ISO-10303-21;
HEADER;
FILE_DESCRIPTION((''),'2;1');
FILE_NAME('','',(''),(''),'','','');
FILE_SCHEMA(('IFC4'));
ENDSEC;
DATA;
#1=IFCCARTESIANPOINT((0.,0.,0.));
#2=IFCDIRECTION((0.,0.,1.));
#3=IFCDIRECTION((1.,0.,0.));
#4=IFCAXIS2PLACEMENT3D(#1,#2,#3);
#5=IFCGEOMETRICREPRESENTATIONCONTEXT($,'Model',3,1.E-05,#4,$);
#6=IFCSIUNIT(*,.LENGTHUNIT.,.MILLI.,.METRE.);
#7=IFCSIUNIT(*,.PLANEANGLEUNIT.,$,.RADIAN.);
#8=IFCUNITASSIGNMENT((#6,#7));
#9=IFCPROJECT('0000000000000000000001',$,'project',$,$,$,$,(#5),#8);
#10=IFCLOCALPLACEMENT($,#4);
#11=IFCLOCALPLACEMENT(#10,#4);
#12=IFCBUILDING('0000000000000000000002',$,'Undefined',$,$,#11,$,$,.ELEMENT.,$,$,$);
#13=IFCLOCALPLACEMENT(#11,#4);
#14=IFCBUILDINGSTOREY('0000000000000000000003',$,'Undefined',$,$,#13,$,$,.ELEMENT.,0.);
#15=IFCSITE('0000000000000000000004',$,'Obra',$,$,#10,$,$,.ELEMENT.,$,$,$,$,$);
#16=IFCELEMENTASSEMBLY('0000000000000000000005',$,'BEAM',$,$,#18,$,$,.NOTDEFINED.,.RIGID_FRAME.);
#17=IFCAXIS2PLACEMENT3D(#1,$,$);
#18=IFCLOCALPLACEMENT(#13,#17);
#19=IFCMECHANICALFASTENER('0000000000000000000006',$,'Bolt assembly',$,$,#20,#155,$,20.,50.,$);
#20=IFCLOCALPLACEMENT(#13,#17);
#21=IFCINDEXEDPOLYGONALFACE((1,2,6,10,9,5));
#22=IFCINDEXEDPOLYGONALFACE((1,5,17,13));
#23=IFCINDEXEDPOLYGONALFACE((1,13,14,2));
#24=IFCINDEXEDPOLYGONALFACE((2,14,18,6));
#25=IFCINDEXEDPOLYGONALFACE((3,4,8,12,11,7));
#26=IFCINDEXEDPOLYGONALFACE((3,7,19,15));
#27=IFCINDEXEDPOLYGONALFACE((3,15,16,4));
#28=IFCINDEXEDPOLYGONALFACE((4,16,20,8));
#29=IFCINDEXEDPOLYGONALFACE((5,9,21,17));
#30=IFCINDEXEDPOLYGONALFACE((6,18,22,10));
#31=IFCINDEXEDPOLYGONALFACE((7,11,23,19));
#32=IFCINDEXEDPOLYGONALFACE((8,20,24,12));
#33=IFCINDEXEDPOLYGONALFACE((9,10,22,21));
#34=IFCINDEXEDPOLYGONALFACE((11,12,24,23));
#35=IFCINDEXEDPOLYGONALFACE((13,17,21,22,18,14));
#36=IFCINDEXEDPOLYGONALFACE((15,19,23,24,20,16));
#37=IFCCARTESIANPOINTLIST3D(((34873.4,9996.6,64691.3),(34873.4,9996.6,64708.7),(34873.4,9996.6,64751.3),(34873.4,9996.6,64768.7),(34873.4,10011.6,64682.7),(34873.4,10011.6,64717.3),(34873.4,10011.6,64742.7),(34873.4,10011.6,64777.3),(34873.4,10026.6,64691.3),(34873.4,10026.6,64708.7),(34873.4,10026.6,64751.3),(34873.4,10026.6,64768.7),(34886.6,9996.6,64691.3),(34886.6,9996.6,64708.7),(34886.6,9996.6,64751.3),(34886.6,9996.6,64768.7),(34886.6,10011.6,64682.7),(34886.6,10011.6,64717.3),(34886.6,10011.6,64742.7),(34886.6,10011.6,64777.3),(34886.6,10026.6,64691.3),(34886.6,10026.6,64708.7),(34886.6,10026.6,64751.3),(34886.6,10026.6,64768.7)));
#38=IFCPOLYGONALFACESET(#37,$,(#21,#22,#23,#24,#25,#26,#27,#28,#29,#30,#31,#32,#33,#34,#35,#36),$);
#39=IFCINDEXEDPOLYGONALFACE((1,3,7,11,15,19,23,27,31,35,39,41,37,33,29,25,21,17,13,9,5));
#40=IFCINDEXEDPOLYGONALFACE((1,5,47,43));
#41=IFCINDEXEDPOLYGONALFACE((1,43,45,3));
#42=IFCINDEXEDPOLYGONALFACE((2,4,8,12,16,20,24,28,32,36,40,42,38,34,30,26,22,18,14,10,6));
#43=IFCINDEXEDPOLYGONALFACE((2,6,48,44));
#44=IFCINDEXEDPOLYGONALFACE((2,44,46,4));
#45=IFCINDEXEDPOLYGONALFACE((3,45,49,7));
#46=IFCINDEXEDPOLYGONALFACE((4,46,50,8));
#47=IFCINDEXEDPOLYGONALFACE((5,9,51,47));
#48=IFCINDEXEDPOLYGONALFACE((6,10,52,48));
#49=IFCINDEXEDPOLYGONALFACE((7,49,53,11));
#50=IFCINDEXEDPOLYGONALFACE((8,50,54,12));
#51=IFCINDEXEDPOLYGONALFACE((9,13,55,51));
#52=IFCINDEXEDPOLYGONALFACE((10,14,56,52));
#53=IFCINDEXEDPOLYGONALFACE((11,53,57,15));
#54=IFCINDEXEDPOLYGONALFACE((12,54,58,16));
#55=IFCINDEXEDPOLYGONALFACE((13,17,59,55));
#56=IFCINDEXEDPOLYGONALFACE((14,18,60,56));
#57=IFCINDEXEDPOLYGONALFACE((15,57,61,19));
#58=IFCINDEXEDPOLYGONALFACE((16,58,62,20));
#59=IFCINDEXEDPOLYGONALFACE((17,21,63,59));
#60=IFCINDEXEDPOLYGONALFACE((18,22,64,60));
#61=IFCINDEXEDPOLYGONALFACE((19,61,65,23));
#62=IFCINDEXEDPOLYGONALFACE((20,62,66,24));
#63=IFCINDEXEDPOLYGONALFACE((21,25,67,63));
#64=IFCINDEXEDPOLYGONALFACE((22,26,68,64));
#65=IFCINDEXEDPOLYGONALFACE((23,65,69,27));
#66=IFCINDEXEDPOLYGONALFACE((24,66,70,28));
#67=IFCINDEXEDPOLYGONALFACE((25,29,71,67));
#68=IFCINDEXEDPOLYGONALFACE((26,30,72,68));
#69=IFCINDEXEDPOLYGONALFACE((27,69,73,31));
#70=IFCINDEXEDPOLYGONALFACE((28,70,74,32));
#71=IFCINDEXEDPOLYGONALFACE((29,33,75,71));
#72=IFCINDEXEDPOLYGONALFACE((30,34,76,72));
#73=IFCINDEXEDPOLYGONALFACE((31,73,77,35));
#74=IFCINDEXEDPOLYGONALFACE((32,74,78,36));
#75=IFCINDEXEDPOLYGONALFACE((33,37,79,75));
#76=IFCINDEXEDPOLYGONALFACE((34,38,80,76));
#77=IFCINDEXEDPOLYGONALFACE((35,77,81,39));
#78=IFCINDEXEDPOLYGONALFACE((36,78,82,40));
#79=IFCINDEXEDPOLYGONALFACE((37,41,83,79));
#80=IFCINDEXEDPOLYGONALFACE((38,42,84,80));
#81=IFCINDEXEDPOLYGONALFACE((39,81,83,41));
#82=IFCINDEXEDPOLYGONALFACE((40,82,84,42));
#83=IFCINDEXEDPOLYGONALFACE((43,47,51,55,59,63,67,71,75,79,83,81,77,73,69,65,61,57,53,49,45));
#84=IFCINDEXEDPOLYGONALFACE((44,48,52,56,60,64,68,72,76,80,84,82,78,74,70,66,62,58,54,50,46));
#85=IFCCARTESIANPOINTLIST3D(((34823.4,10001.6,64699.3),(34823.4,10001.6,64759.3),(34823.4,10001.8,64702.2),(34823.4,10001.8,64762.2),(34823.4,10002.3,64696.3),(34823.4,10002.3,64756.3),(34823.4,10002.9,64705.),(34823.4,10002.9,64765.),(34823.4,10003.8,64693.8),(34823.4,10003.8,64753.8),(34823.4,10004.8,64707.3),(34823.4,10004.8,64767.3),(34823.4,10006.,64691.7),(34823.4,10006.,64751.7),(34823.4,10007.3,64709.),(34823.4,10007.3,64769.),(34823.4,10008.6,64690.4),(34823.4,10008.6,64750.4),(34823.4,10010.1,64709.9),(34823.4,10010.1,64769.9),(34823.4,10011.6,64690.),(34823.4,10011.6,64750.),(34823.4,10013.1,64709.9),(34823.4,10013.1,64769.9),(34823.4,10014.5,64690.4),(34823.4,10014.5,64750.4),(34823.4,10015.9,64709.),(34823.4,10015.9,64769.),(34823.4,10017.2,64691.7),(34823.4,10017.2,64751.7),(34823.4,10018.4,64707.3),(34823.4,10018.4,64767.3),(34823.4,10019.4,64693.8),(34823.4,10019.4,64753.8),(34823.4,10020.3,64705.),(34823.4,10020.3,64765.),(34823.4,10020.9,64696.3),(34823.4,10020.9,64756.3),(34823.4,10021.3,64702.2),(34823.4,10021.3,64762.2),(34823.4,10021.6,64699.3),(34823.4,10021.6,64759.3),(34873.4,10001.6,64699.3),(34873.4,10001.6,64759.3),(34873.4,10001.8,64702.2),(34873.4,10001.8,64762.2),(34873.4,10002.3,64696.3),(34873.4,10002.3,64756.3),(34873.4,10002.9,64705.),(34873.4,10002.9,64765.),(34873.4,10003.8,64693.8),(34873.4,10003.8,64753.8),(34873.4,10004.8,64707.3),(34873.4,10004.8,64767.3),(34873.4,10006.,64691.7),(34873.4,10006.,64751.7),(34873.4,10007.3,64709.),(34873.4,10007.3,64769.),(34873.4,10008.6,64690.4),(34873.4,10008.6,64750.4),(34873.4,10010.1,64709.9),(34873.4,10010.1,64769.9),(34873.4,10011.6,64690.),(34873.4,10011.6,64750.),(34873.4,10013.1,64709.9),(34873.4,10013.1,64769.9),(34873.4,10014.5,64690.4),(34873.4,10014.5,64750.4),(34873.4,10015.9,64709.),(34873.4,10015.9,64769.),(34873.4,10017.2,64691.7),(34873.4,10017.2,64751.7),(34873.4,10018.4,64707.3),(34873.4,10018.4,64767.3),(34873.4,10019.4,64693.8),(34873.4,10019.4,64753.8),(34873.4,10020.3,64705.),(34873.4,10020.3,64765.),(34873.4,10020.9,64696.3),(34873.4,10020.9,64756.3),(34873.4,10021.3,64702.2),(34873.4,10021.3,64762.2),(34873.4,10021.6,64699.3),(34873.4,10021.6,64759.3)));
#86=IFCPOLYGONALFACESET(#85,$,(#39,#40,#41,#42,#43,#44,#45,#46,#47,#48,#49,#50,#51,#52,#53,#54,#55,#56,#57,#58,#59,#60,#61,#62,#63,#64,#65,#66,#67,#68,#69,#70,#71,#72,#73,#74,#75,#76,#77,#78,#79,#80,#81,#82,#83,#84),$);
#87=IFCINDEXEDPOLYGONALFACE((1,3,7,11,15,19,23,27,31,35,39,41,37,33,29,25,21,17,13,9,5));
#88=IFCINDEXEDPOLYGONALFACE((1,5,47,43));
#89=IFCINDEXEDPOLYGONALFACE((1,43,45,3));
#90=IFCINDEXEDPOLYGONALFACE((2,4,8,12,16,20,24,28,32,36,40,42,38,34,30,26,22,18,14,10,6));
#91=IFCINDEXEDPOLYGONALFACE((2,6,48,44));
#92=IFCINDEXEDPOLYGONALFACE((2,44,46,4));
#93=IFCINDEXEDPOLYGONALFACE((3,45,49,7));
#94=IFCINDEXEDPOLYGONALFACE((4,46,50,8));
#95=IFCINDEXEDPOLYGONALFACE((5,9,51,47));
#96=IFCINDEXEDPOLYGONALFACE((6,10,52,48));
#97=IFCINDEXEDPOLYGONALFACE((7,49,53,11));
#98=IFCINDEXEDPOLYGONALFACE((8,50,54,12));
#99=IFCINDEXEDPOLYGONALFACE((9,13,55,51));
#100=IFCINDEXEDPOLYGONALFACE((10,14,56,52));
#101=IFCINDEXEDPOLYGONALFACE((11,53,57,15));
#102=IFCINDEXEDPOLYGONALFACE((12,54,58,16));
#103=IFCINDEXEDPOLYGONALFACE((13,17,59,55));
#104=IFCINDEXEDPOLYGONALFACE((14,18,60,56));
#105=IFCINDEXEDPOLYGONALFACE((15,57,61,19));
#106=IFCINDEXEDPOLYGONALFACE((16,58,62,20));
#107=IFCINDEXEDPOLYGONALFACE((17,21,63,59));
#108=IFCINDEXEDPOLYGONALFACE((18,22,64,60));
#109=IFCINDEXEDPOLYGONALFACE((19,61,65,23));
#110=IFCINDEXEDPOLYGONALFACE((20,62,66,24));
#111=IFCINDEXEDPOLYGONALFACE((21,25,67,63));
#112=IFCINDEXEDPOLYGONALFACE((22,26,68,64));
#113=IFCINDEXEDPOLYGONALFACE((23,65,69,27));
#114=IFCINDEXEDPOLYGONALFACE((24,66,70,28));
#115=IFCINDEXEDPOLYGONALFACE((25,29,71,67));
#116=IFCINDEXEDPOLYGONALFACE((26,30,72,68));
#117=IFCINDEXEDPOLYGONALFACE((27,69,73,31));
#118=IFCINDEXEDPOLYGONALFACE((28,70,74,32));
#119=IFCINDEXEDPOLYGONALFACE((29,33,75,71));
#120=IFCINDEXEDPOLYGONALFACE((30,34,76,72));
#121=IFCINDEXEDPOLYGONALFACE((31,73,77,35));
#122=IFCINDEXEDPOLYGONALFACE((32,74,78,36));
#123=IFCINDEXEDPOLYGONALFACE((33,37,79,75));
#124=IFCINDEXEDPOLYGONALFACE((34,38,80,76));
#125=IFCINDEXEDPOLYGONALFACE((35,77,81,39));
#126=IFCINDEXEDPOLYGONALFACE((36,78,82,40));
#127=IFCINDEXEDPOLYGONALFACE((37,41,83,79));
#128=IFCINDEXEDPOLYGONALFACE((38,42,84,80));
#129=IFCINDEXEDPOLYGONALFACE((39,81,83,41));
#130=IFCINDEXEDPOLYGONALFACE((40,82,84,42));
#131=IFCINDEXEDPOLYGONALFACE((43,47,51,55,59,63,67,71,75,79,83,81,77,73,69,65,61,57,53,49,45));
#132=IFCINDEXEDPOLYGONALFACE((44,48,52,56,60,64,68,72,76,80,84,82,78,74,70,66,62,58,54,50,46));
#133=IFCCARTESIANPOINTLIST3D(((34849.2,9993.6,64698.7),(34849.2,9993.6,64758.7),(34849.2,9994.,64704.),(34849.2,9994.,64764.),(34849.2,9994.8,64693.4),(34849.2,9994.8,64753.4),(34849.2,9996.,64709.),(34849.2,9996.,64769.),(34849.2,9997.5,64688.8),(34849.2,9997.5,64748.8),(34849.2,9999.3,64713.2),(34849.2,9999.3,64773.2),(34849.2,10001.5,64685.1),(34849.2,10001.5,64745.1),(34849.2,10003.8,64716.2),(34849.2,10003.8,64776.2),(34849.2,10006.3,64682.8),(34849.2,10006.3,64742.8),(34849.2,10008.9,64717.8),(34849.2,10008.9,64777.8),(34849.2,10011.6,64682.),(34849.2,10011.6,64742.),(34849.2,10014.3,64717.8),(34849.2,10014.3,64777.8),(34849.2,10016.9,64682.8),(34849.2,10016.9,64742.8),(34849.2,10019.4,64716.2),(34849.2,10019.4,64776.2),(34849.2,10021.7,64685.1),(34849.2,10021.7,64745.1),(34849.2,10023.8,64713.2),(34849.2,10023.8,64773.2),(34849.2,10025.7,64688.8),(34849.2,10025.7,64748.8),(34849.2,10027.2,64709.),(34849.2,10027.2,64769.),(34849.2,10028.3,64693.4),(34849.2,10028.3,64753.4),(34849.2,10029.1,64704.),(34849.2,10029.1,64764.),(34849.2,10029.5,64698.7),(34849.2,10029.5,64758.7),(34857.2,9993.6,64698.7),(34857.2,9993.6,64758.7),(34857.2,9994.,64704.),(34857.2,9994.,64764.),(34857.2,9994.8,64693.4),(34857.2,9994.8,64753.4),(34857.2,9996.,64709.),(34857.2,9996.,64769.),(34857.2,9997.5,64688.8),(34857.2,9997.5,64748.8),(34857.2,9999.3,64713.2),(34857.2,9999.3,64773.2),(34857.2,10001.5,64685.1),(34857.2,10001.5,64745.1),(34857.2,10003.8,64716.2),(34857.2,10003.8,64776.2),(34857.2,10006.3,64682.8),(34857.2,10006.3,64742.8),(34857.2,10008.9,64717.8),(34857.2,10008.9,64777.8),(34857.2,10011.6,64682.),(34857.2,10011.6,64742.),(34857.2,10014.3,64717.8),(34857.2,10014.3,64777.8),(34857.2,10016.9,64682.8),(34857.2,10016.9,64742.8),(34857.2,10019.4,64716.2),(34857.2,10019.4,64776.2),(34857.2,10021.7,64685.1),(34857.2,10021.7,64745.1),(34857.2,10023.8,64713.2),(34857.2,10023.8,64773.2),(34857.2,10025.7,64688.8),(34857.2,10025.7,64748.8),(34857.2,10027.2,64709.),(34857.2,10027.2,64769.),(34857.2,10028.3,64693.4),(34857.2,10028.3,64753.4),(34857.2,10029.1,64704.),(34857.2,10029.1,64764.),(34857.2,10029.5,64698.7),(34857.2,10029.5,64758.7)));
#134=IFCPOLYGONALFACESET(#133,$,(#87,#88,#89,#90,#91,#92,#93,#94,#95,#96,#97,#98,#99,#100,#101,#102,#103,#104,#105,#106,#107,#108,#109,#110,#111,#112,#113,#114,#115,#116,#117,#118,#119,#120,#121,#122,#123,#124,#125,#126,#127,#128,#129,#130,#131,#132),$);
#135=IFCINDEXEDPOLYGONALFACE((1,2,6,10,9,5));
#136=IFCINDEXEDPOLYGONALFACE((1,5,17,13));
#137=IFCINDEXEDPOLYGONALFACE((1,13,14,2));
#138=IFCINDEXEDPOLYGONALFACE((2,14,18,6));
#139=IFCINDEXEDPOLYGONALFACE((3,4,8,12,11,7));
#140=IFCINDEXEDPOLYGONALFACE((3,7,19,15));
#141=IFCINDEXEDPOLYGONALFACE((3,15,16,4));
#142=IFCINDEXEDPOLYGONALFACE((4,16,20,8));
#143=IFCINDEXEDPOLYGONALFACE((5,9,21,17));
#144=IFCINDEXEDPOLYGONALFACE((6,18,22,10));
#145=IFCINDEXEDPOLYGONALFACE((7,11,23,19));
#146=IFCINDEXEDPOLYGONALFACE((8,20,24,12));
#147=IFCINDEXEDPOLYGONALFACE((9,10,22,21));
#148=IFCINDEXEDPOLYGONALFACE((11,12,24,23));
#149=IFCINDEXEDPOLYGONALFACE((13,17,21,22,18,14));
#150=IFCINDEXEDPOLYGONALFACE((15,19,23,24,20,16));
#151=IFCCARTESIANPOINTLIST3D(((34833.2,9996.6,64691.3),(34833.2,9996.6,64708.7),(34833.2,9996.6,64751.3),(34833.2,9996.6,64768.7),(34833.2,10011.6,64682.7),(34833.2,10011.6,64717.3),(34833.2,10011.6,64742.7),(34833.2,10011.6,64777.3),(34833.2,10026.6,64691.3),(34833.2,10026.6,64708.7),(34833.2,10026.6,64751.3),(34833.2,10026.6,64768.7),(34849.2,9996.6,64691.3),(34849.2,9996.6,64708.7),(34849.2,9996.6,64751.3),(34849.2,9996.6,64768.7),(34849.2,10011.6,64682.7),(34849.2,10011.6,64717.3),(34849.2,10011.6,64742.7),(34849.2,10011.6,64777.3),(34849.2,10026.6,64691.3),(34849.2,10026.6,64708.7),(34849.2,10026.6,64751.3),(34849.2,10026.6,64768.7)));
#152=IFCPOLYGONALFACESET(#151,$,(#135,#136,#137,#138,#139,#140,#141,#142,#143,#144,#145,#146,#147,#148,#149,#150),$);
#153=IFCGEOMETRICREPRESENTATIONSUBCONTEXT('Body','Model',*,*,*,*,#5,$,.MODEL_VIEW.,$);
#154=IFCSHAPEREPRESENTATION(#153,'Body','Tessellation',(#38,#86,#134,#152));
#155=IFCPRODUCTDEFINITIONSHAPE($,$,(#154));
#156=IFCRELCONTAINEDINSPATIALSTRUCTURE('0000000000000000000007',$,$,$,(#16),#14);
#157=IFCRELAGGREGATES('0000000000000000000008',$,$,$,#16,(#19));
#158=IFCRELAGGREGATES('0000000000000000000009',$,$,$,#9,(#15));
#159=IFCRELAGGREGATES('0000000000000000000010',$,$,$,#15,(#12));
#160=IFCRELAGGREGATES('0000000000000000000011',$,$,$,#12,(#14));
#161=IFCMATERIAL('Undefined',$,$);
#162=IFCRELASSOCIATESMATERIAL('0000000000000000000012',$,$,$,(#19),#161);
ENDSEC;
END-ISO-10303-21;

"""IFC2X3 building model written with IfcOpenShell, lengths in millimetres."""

from ifc_helpers import new_model, si_unit, frame, origin_with_axes, origin_2d_with_axis, place, context, subcontext, project, spatial, polyline, circle, outline, extrude, source, transform, mapped, material, element, aggregate, save


model = new_model("IFC2X3")

# Units and contexts
model_context = context("Model", 3, precision=1e-05, world=origin_with_axes())
body_context = subcontext(model_context, "Body", "Model", "MODEL_VIEW")
ifc_project = project(units=[si_unit("LENGTHUNIT", "METRE", prefix="MILLI"), si_unit("PLANEANGLEUNIT", "RADIAN")], contexts=[model_context])

# Site, building, storey
site_placement = place(None, origin_with_axes())
site = spatial("IfcSite", under=ifc_project, at=site_placement, Name="Obra", CompositionType="ELEMENT")
building_placement = place(site_placement, origin_with_axes())
building = spatial("IfcBuilding", under=site, at=building_placement, Name="Undefined", CompositionType="ELEMENT")
storey_placement = place(building_placement, origin_with_axes())
storey = spatial("IfcBuildingStorey", under=building, at=storey_placement, Name="Undefined", CompositionType="ELEMENT", Elevation=0.0)

# Shared definitions
ifc_material = material(Name="Undefined")

# Element assembly, mechanical fastener
shared_shape_1 = source(origin_with_axes(), body_context, "Body", "SweptSolid", [
    extrude(outline(polyline([(17.3, 0.0), (8.7, 15.0), (-8.7, 15.0), (-17.3, 0.0), (-8.7, -15.0), (8.7, -15.0), (17.3, 0.0)])), frame((0.0, -26.3, 0.0), z_axis=(0.0, 1.0, 0.0), x_axis=(1.0, 0.0, 0.0)), (0.0, 0.0, 1.0), 13.2),
    extrude(circle(Radius=10.0, at=origin_2d_with_axis()), frame((0.0, -13.1, 0.0), z_axis=(0.0, 1.0, 0.0), x_axis=(1.0, 0.0, 0.0)), (0.0, 0.0, 1.0), 50.0),
    extrude(circle(Radius=18.0, at=origin_2d_with_axis()), frame((0.0, 3.1, 0.0), z_axis=(0.0, 1.0, 0.0), x_axis=(1.0, 0.0, 0.0)), (0.0, 0.0, 1.0), 8.0),
    extrude(outline(polyline([(17.3, 0.0), (8.7, 15.0), (-8.7, 15.0), (-17.3, 0.0), (-8.7, -15.0), (8.7, -15.0), (17.3, 0.0)])), frame((0.0, 11.1, 0.0), z_axis=(0.0, 1.0, 0.0), x_axis=(1.0, 0.0, 0.0)), (0.0, 0.0, 1.0), 16.0),
])
assembly_1_placement = place(storey_placement, origin_with_axes())
assembly_1 = element("IfcElementAssembly", 1, at=assembly_1_placement, inside=storey, Name="BEAM", AssemblyPlace="NOTDEFINED", PredefinedType="RIGID_FRAME")
mechanical_fastener_1_placement = place(assembly_1_placement, frame((34860.3, 9971.6, 64850.0), z_axis=(0.0, 1.0, 0.0), x_axis=(0.0, 0.0, -1.0)))
mechanical_fastener_1 = element("IfcMechanicalFastener", 2, at=mechanical_fastener_1_placement, material=ifc_material, Name="Bolt assembly", NominalDiameter=20.0, NominalLength=50.0, context=body_context, shape_type="MappedRepresentation", body=[
    mapped(shared_shape_1, transform((90.0, 0.0, 40.0))),
    mapped(shared_shape_1, transform((150.0, 0.0, 40.0))),
])

aggregate(assembly_1, [mechanical_fastener_1])

save(model, "model.ifc")
